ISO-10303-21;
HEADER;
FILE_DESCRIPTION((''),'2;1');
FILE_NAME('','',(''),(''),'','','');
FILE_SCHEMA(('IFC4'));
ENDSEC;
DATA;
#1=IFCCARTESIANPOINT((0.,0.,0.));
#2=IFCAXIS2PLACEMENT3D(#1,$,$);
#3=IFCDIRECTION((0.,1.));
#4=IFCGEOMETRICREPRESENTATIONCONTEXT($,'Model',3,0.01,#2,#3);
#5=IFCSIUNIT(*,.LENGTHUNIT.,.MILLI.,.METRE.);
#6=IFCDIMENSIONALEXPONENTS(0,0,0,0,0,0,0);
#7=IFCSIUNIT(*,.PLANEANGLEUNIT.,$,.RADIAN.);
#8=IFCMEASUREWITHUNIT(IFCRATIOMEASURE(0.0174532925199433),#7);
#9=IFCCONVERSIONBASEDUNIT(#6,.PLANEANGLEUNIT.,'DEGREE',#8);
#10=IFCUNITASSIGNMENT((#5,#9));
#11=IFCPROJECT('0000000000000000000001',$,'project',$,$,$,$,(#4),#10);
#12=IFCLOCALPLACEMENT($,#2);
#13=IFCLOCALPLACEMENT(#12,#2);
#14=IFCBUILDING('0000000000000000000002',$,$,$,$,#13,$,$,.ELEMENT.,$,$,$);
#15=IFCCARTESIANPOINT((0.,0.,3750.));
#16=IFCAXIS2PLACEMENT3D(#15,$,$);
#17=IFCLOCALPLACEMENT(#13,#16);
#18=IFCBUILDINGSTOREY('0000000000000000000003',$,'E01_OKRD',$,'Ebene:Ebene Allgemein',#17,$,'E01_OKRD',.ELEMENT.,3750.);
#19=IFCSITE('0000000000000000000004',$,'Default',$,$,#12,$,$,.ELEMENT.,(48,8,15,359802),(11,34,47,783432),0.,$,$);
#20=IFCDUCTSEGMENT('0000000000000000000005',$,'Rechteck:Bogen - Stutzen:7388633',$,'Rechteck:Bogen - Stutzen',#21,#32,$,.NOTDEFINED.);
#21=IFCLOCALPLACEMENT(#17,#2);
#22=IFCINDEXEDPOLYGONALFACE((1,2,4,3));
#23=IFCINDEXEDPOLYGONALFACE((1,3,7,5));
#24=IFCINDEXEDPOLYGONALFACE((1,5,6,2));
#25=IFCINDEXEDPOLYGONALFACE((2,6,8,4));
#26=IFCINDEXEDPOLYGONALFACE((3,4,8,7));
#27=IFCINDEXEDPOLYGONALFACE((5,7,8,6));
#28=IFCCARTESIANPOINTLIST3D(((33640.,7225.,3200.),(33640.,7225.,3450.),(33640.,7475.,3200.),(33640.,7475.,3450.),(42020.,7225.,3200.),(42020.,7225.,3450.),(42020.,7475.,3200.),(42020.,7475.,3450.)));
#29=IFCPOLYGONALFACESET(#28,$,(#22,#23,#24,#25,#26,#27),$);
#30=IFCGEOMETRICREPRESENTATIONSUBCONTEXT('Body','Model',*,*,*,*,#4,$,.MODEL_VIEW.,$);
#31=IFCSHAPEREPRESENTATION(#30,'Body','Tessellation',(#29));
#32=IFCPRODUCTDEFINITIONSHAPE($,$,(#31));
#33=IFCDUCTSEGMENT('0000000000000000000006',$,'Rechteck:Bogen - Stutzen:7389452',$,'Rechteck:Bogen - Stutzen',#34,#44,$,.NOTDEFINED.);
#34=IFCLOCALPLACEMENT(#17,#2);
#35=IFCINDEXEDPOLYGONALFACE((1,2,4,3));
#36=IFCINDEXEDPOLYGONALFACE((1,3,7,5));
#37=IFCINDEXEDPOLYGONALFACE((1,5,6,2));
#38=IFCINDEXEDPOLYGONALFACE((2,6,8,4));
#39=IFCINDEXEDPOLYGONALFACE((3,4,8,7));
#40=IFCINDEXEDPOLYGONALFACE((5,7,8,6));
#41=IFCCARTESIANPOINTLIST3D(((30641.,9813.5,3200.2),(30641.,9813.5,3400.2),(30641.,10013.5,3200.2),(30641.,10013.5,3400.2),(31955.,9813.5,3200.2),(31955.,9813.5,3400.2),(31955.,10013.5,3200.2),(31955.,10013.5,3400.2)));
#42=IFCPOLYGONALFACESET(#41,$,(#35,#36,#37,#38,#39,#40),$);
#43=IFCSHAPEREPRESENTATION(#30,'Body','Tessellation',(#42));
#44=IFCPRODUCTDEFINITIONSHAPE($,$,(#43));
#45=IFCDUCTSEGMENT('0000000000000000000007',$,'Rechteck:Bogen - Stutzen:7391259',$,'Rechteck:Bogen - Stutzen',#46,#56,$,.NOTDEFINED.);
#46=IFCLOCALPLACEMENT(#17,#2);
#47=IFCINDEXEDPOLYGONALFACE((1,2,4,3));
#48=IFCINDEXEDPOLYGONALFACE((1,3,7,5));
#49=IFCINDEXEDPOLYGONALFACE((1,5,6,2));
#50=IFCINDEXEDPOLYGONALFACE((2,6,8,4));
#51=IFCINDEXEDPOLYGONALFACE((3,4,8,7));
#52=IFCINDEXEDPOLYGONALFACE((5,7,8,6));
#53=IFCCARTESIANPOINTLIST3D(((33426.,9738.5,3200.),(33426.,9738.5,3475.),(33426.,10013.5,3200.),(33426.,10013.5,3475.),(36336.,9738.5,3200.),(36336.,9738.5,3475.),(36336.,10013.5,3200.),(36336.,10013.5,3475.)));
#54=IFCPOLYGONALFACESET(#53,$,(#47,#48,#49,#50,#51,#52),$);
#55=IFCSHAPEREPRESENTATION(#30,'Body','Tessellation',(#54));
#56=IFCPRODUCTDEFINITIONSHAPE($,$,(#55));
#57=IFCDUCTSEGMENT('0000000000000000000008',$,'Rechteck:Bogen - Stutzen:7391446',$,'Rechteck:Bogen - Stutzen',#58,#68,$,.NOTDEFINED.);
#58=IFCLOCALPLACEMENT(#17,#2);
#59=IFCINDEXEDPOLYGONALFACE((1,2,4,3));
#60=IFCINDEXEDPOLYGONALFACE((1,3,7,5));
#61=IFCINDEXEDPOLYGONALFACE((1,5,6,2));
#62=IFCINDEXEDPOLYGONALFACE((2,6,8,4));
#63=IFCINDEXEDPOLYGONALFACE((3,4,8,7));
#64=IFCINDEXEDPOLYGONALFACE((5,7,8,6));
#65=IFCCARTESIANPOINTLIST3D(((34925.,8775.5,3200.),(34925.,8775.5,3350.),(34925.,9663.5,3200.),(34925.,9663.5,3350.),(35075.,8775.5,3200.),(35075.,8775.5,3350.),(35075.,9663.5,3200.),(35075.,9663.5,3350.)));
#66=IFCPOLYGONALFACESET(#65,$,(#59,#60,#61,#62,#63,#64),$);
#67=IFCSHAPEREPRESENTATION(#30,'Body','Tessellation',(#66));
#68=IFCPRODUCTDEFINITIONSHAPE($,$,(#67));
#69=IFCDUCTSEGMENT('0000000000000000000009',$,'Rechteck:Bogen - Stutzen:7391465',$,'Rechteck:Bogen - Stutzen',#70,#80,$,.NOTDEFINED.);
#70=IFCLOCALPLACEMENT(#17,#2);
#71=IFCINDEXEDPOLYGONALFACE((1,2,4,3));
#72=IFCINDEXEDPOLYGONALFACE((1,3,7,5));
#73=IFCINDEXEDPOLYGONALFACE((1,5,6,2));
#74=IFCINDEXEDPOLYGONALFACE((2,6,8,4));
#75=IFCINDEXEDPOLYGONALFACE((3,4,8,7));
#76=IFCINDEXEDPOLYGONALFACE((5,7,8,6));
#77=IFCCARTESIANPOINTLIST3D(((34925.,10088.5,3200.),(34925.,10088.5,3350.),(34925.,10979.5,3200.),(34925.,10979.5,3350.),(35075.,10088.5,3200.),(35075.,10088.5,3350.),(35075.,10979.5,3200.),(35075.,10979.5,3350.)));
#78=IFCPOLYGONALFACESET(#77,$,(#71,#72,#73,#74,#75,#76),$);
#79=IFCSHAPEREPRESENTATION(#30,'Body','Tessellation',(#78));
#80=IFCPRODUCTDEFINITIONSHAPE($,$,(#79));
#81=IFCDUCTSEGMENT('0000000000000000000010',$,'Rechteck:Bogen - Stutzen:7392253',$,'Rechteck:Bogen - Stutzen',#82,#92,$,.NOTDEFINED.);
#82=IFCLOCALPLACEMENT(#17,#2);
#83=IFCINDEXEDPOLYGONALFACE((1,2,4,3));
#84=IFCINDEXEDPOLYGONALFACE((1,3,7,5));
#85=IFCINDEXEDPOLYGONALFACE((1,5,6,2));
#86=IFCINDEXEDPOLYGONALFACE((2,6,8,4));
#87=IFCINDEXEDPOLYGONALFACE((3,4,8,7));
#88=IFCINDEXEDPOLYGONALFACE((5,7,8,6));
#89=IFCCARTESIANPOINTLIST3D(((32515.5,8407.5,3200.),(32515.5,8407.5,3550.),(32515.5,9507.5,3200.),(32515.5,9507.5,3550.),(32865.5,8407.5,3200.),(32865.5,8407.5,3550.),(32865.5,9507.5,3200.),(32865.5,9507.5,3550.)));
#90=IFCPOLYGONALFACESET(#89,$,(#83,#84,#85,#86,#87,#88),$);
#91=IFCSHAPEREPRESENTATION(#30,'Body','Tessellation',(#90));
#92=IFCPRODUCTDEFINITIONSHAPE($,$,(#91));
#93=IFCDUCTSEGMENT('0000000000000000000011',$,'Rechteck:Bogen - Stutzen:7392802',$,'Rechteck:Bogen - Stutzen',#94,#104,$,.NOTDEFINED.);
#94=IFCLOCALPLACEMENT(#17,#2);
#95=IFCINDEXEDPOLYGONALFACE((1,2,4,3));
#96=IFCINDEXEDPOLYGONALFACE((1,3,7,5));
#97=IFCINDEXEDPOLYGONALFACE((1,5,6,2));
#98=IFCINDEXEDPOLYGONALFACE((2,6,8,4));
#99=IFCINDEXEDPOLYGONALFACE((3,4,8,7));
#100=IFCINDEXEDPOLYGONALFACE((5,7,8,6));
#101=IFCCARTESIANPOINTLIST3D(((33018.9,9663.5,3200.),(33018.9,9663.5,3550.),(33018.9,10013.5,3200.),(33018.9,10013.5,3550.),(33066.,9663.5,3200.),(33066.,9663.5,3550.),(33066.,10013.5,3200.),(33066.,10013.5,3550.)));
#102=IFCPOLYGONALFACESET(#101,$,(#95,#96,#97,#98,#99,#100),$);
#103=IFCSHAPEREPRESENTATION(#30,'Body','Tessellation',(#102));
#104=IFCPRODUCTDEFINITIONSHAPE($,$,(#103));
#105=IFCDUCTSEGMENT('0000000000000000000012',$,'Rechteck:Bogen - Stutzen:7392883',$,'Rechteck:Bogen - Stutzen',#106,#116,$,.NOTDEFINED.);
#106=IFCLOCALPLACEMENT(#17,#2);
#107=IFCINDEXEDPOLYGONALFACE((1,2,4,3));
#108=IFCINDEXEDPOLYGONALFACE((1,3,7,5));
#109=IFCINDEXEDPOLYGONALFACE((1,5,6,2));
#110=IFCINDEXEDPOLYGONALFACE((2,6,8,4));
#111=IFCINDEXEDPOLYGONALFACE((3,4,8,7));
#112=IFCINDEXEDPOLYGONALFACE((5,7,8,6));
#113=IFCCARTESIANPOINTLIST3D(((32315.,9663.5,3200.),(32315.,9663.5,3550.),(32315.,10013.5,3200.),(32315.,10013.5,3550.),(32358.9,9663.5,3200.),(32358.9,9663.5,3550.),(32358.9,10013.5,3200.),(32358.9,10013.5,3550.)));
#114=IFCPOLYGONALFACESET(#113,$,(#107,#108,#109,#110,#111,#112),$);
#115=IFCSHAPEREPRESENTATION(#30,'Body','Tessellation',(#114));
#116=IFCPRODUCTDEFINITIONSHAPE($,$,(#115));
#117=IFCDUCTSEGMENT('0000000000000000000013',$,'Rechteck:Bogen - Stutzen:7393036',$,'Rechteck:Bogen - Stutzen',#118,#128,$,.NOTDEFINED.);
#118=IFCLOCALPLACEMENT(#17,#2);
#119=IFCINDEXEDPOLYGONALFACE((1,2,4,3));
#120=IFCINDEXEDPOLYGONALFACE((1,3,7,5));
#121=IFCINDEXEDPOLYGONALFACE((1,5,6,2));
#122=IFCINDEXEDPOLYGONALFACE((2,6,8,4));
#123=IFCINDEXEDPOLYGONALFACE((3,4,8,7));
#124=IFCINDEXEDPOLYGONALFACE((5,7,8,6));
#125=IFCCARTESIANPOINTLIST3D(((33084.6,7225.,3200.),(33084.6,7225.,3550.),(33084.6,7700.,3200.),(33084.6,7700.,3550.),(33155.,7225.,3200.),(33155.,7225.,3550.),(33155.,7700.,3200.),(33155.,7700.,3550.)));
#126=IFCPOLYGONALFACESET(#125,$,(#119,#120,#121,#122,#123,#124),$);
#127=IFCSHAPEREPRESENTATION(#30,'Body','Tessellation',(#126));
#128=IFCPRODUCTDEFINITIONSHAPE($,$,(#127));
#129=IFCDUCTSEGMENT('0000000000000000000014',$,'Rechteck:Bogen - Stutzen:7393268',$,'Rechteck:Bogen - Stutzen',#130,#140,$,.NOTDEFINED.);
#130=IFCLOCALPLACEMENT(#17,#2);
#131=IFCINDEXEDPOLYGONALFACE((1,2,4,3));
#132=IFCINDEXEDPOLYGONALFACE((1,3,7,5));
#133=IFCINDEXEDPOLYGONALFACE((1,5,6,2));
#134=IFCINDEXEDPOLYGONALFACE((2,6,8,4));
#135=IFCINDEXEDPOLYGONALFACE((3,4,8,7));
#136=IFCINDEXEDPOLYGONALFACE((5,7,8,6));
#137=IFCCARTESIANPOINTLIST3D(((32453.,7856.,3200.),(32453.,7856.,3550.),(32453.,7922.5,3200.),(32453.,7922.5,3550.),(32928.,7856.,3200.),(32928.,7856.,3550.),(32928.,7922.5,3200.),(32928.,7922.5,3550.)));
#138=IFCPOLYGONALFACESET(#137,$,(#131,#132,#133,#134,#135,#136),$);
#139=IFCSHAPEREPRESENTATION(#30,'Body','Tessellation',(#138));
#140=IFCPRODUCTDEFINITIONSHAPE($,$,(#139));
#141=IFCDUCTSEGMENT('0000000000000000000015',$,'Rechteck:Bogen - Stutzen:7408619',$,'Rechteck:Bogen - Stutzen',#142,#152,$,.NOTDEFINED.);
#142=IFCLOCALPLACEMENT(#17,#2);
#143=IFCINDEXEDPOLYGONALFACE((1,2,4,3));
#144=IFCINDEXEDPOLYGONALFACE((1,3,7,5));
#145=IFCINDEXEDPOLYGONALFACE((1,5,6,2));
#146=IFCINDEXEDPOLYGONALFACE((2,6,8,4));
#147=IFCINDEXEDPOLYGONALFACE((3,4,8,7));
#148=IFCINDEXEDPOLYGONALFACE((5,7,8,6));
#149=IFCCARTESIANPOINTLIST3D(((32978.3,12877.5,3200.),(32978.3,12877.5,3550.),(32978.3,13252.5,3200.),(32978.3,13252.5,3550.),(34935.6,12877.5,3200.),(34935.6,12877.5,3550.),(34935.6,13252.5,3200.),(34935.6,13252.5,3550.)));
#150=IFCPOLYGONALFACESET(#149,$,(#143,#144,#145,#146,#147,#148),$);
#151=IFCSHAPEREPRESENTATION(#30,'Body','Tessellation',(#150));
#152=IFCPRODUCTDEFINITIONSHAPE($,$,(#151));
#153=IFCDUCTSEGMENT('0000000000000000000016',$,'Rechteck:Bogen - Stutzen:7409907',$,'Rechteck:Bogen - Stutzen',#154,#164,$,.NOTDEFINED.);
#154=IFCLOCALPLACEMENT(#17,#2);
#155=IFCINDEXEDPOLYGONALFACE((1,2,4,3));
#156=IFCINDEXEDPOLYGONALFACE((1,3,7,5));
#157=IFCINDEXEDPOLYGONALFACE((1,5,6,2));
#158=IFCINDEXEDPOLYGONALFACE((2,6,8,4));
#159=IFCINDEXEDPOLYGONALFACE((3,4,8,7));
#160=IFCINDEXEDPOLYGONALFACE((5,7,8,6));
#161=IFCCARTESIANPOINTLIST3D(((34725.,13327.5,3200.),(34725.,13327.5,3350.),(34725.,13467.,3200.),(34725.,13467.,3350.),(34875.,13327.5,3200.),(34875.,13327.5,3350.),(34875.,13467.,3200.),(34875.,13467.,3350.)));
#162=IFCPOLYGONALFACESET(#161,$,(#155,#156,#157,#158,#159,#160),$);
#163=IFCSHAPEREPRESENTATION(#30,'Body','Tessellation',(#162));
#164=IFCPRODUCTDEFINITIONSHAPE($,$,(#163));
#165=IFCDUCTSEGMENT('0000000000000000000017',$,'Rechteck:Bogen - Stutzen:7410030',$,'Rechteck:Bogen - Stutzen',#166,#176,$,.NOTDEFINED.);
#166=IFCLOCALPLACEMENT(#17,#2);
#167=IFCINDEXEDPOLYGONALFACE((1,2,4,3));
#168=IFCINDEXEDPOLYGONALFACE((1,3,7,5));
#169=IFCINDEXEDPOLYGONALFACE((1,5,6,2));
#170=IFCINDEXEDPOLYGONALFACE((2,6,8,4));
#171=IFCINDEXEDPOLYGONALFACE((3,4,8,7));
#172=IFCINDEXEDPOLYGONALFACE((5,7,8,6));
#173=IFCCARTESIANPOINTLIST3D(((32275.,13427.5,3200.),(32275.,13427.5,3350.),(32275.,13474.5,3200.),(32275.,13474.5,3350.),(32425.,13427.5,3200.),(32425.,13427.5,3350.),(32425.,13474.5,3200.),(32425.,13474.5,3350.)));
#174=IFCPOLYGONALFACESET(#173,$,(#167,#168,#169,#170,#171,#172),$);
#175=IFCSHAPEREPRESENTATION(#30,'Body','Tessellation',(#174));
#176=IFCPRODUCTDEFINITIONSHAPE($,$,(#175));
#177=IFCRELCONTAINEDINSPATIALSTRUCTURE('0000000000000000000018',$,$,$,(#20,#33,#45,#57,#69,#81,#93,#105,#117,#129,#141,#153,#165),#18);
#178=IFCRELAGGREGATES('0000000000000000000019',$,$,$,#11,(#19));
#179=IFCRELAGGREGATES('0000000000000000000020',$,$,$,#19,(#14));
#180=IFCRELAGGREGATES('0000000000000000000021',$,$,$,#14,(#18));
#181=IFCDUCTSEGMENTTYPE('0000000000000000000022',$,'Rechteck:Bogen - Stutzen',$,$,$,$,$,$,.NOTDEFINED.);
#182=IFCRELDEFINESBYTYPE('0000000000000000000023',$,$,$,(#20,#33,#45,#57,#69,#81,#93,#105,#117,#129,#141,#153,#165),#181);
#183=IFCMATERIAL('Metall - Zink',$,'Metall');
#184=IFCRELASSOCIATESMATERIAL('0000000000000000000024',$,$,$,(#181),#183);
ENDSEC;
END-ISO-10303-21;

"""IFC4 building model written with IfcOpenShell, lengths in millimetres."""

from ifc_helpers import new_model, entity, si_unit, converted_unit, direction, frame, frame_2d, origin, origin_2d_with_axis, place, context, subcontext, project, spatial, rectangle, extrude, material, type_object, element, save


model = new_model("IFC4")

# Units and contexts
model_context = context("Model", 3, precision=0.01, world=origin(), true_north=direction((0.0, 1.0)))
body_context = subcontext(model_context, "Body", "Model", "MODEL_VIEW")
ifc_project = project(units=[si_unit("LENGTHUNIT", "METRE", prefix="MILLI"), converted_unit("PLANEANGLEUNIT", "DEGREE", entity("IfcRatioMeasure", 0.0174532925199433), si_unit("PLANEANGLEUNIT", "RADIAN"), dimensions=[0, 0, 0, 0, 0, 0, 0])], contexts=[model_context])

# Site, building, storey
site_placement = place(None, origin())
site = spatial("IfcSite", under=ifc_project, at=site_placement, Name="Default", CompositionType="ELEMENT", RefLatitude=(48, 8, 15, 359802), RefLongitude=(11, 34, 47, 783432), RefElevation=0.0)
building_placement = place(site_placement, origin())
building = spatial("IfcBuilding", under=site, at=building_placement, CompositionType="ELEMENT")
storey_placement = place(building_placement, frame((0.0, 0.0, 3750.0)))
storey = spatial("IfcBuildingStorey", under=building, at=storey_placement, Name="E01_OKRD", ObjectType="Ebene:Ebene Allgemein", LongName="E01_OKRD", CompositionType="ELEMENT", Elevation=3750.0)

# Duct segments
ifc_material_1 = material(Name="Metall - Zink", Category="Metall")
duct_segment_type_1 = type_object("IfcDuctSegmentType", Name="Rechteck:Bogen - Stutzen", PredefinedType="NOTDEFINED", material=ifc_material_1)
duct_segment_1_placement = place(storey_placement, frame((33640.0, 7225.0, 3200.0)))
element("IfcDuctSegment", 1, at=duct_segment_1_placement, inside=storey, type_object=duct_segment_type_1, Name="Rechteck:Bogen - Stutzen:7388633", ObjectType="Rechteck:Bogen - Stutzen", PredefinedType="NOTDEFINED", context=body_context, shape_type="SweptSolid", body=[
    extrude(rectangle(XDim=8380.0, YDim=250.0, at=frame_2d((0.0, 0.0), x_axis=(1.0, 0.0))), frame((4190.0, 125.0, 0.0), z_axis=(0.0, 0.0, 1.0), x_axis=(-1.0, 0.0, 0.0)), (0.0, 0.0, 1.0), 250.0),
])
duct_segment_2_placement = place(storey_placement, frame((30641.0, 9813.5, 3200.2)))
element("IfcDuctSegment", 2, at=duct_segment_2_placement, inside=storey, type_object=duct_segment_type_1, Name="Rechteck:Bogen - Stutzen:7389452", ObjectType="Rechteck:Bogen - Stutzen", PredefinedType="NOTDEFINED", context=body_context, shape_type="SweptSolid", body=[
    extrude(rectangle(XDim=1314.0, YDim=200.0, at=frame_2d((0.0, 0.0), x_axis=(1.0, 0.0))), frame((657.0, 100.0, 0.0)), (0.0, 0.0, 1.0), 200.0),
])
duct_segment_3_placement = place(storey_placement, frame((33426.0, 9738.5, 3200.0)))
element("IfcDuctSegment", 3, at=duct_segment_3_placement, inside=storey, type_object=duct_segment_type_1, Name="Rechteck:Bogen - Stutzen:7391259", ObjectType="Rechteck:Bogen - Stutzen", PredefinedType="NOTDEFINED", context=body_context, shape_type="SweptSolid", body=[
    extrude(rectangle(XDim=2910.0, YDim=275.0, at=frame_2d((0.0, 0.0), x_axis=(1.0, 0.0))), frame((1455.0, 137.5, 0.0), z_axis=(0.0, 0.0, 1.0), x_axis=(-1.0, 0.0, 0.0)), (0.0, 0.0, 1.0), 275.0),
])
duct_segment_4_placement = place(storey_placement, frame((34925.0, 8775.5, 3200.0)))
element("IfcDuctSegment", 4, at=duct_segment_4_placement, inside=storey, type_object=duct_segment_type_1, Name="Rechteck:Bogen - Stutzen:7391446", ObjectType="Rechteck:Bogen - Stutzen", PredefinedType="NOTDEFINED", context=body_context, shape_type="SweptSolid", body=[
    extrude(rectangle(XDim=888.0, YDim=150.0, at=frame_2d((0.0, 0.0), x_axis=(1.0, 0.0))), frame((75.0, 444.0, 0.0), z_axis=(0.0, 0.000027, 1.0), x_axis=(0.0, 1.0, -0.000027)), (0.0, 0.0, 1.0), 150.0),
])
duct_segment_5_placement = place(storey_placement, frame((34925.0, 10088.5, 3200.0)))
element("IfcDuctSegment", 5, at=duct_segment_5_placement, inside=storey, type_object=duct_segment_type_1, Name="Rechteck:Bogen - Stutzen:7391465", ObjectType="Rechteck:Bogen - Stutzen", PredefinedType="NOTDEFINED", context=body_context, shape_type="SweptSolid", body=[
    extrude(rectangle(XDim=891.0, YDim=150.0, at=frame_2d((0.0, 0.0), x_axis=(1.0, 0.0))), frame((75.0, 445.5, 0.0), z_axis=(0.0, -0.000046, 1.0), x_axis=(0.0, -1.0, -0.000046)), (0.0, 0.0, 1.0), 150.0),
])
duct_segment_6_placement = place(storey_placement, frame((32515.5, 8407.5, 3200.0)))
element("IfcDuctSegment", 6, at=duct_segment_6_placement, inside=storey, type_object=duct_segment_type_1, Name="Rechteck:Bogen - Stutzen:7392253", ObjectType="Rechteck:Bogen - Stutzen", PredefinedType="NOTDEFINED", context=body_context, shape_type="SweptSolid", body=[
    extrude(rectangle(XDim=1100.0, YDim=350.0, at=frame_2d((0.0, 0.0), x_axis=(1.0, 0.0))), frame((175.0, 550.0, 0.0), z_axis=(0.0, 0.0, 1.0), x_axis=(0.0, -1.0, 0.0)), (0.0, 0.0, 1.0), 350.0),
])
duct_segment_7_placement = place(storey_placement, frame((33018.9, 9663.5, 3200.0)))
element("IfcDuctSegment", 7, at=duct_segment_7_placement, inside=storey, type_object=duct_segment_type_1, Name="Rechteck:Bogen - Stutzen:7392802", ObjectType="Rechteck:Bogen - Stutzen", PredefinedType="NOTDEFINED", context=body_context, shape_type="SweptSolid", body=[
    extrude(rectangle(XDim=47.1, YDim=350.0, at=frame_2d((0.0, 0.0), x_axis=(1.0, 0.0))), frame((23.5, 175.0, 0.0), z_axis=(0.0, 0.0, 1.0), x_axis=(-1.0, 0.0, 0.0)), (0.0, 0.0, 1.0), 350.0),
])
duct_segment_8_placement = place(storey_placement, frame((32315.0, 9663.5, 3200.0)))
element("IfcDuctSegment", 8, at=duct_segment_8_placement, inside=storey, type_object=duct_segment_type_1, Name="Rechteck:Bogen - Stutzen:7392883", ObjectType="Rechteck:Bogen - Stutzen", PredefinedType="NOTDEFINED", context=body_context, shape_type="SweptSolid", body=[
    extrude(rectangle(XDim=43.9, YDim=350.0, at=frame_2d((0.0, 0.0), x_axis=(1.0, 0.0))), frame((22.0, 175.0, 0.0)), (0.0, 0.0, 1.0), 350.0),
])
duct_segment_9_placement = place(storey_placement, frame((33084.6, 7225.0, 3200.0)))
element("IfcDuctSegment", 9, at=duct_segment_9_placement, inside=storey, type_object=duct_segment_type_1, Name="Rechteck:Bogen - Stutzen:7393036", ObjectType="Rechteck:Bogen - Stutzen", PredefinedType="NOTDEFINED", context=body_context, shape_type="SweptSolid", body=[
    extrude(rectangle(XDim=70.4, YDim=475.0, at=frame_2d((0.0, 0.0), x_axis=(1.0, 0.0))), frame((35.2, 237.5, 0.0), z_axis=(0.0, 0.0, 1.0), x_axis=(-1.0, 0.0, 0.0)), (0.0, 0.0, 1.0), 350.0),
])
duct_segment_10_placement = place(storey_placement, frame((32453.0, 7856.0, 3200.0)))
element("IfcDuctSegment", 10, at=duct_segment_10_placement, inside=storey, type_object=duct_segment_type_1, Name="Rechteck:Bogen - Stutzen:7393268", ObjectType="Rechteck:Bogen - Stutzen", PredefinedType="NOTDEFINED", context=body_context, shape_type="SweptSolid", body=[
    extrude(rectangle(XDim=66.5, YDim=475.0, at=frame_2d((0.0, 0.0), x_axis=(1.0, 0.0))), frame((237.5, 33.3, 0.0), z_axis=(0.0, 0.0, 1.0), x_axis=(0.0, -1.0, 0.0)), (0.0, 0.0, 1.0), 350.0),
])
duct_segment_11_placement = place(storey_placement, frame((32978.3, 12877.5, 3200.0)))
element("IfcDuctSegment", 11, at=duct_segment_11_placement, inside=storey, type_object=duct_segment_type_1, Name="Rechteck:Bogen - Stutzen:7408619", ObjectType="Rechteck:Bogen - Stutzen", PredefinedType="NOTDEFINED", context=body_context, shape_type="SweptSolid", body=[
    extrude(rectangle(XDim=1957.3, YDim=375.0, at=frame_2d((0.0, 0.0), x_axis=(1.0, 0.0))), frame((978.6, 187.5, 0.0), z_axis=(0.0, 0.0, 1.0), x_axis=(-1.0, 0.0, 0.0)), (0.0, 0.0, 1.0), 350.0),
])
duct_segment_12_placement = place(storey_placement, frame((34725.0, 13327.5, 3200.0)))
element("IfcDuctSegment", 12, at=duct_segment_12_placement, inside=storey, type_object=duct_segment_type_1, Name="Rechteck:Bogen - Stutzen:7409907", ObjectType="Rechteck:Bogen - Stutzen", PredefinedType="NOTDEFINED", context=body_context, shape_type="SweptSolid", body=[
    extrude(rectangle(XDim=139.5, YDim=150.0, at=frame_2d((0.0, 0.0), x_axis=(1.0, 0.0))), frame((75.0, 69.8, 0.0), z_axis=(0.0, 0.0, 1.0), x_axis=(0.0, -1.0, 0.0)), (0.0, 0.0, 1.0), 150.0),
])
duct_segment_13_placement = place(storey_placement, frame((32275.0, 13427.5, 3200.0)))
element("IfcDuctSegment", 13, at=duct_segment_13_placement, inside=storey, type_object=duct_segment_type_1, Name="Rechteck:Bogen - Stutzen:7410030", ObjectType="Rechteck:Bogen - Stutzen", PredefinedType="NOTDEFINED", context=body_context, shape_type="SweptSolid", body=[
    extrude(rectangle(XDim=47.0, YDim=150.0, at=origin_2d_with_axis()), frame((75.0, 23.5, 0.0), z_axis=(0.0, 0.0, 1.0), x_axis=(0.0, -1.0, 0.0)), (0.0, 0.0, 1.0), 150.0),
])

save(model, "model.ifc")
